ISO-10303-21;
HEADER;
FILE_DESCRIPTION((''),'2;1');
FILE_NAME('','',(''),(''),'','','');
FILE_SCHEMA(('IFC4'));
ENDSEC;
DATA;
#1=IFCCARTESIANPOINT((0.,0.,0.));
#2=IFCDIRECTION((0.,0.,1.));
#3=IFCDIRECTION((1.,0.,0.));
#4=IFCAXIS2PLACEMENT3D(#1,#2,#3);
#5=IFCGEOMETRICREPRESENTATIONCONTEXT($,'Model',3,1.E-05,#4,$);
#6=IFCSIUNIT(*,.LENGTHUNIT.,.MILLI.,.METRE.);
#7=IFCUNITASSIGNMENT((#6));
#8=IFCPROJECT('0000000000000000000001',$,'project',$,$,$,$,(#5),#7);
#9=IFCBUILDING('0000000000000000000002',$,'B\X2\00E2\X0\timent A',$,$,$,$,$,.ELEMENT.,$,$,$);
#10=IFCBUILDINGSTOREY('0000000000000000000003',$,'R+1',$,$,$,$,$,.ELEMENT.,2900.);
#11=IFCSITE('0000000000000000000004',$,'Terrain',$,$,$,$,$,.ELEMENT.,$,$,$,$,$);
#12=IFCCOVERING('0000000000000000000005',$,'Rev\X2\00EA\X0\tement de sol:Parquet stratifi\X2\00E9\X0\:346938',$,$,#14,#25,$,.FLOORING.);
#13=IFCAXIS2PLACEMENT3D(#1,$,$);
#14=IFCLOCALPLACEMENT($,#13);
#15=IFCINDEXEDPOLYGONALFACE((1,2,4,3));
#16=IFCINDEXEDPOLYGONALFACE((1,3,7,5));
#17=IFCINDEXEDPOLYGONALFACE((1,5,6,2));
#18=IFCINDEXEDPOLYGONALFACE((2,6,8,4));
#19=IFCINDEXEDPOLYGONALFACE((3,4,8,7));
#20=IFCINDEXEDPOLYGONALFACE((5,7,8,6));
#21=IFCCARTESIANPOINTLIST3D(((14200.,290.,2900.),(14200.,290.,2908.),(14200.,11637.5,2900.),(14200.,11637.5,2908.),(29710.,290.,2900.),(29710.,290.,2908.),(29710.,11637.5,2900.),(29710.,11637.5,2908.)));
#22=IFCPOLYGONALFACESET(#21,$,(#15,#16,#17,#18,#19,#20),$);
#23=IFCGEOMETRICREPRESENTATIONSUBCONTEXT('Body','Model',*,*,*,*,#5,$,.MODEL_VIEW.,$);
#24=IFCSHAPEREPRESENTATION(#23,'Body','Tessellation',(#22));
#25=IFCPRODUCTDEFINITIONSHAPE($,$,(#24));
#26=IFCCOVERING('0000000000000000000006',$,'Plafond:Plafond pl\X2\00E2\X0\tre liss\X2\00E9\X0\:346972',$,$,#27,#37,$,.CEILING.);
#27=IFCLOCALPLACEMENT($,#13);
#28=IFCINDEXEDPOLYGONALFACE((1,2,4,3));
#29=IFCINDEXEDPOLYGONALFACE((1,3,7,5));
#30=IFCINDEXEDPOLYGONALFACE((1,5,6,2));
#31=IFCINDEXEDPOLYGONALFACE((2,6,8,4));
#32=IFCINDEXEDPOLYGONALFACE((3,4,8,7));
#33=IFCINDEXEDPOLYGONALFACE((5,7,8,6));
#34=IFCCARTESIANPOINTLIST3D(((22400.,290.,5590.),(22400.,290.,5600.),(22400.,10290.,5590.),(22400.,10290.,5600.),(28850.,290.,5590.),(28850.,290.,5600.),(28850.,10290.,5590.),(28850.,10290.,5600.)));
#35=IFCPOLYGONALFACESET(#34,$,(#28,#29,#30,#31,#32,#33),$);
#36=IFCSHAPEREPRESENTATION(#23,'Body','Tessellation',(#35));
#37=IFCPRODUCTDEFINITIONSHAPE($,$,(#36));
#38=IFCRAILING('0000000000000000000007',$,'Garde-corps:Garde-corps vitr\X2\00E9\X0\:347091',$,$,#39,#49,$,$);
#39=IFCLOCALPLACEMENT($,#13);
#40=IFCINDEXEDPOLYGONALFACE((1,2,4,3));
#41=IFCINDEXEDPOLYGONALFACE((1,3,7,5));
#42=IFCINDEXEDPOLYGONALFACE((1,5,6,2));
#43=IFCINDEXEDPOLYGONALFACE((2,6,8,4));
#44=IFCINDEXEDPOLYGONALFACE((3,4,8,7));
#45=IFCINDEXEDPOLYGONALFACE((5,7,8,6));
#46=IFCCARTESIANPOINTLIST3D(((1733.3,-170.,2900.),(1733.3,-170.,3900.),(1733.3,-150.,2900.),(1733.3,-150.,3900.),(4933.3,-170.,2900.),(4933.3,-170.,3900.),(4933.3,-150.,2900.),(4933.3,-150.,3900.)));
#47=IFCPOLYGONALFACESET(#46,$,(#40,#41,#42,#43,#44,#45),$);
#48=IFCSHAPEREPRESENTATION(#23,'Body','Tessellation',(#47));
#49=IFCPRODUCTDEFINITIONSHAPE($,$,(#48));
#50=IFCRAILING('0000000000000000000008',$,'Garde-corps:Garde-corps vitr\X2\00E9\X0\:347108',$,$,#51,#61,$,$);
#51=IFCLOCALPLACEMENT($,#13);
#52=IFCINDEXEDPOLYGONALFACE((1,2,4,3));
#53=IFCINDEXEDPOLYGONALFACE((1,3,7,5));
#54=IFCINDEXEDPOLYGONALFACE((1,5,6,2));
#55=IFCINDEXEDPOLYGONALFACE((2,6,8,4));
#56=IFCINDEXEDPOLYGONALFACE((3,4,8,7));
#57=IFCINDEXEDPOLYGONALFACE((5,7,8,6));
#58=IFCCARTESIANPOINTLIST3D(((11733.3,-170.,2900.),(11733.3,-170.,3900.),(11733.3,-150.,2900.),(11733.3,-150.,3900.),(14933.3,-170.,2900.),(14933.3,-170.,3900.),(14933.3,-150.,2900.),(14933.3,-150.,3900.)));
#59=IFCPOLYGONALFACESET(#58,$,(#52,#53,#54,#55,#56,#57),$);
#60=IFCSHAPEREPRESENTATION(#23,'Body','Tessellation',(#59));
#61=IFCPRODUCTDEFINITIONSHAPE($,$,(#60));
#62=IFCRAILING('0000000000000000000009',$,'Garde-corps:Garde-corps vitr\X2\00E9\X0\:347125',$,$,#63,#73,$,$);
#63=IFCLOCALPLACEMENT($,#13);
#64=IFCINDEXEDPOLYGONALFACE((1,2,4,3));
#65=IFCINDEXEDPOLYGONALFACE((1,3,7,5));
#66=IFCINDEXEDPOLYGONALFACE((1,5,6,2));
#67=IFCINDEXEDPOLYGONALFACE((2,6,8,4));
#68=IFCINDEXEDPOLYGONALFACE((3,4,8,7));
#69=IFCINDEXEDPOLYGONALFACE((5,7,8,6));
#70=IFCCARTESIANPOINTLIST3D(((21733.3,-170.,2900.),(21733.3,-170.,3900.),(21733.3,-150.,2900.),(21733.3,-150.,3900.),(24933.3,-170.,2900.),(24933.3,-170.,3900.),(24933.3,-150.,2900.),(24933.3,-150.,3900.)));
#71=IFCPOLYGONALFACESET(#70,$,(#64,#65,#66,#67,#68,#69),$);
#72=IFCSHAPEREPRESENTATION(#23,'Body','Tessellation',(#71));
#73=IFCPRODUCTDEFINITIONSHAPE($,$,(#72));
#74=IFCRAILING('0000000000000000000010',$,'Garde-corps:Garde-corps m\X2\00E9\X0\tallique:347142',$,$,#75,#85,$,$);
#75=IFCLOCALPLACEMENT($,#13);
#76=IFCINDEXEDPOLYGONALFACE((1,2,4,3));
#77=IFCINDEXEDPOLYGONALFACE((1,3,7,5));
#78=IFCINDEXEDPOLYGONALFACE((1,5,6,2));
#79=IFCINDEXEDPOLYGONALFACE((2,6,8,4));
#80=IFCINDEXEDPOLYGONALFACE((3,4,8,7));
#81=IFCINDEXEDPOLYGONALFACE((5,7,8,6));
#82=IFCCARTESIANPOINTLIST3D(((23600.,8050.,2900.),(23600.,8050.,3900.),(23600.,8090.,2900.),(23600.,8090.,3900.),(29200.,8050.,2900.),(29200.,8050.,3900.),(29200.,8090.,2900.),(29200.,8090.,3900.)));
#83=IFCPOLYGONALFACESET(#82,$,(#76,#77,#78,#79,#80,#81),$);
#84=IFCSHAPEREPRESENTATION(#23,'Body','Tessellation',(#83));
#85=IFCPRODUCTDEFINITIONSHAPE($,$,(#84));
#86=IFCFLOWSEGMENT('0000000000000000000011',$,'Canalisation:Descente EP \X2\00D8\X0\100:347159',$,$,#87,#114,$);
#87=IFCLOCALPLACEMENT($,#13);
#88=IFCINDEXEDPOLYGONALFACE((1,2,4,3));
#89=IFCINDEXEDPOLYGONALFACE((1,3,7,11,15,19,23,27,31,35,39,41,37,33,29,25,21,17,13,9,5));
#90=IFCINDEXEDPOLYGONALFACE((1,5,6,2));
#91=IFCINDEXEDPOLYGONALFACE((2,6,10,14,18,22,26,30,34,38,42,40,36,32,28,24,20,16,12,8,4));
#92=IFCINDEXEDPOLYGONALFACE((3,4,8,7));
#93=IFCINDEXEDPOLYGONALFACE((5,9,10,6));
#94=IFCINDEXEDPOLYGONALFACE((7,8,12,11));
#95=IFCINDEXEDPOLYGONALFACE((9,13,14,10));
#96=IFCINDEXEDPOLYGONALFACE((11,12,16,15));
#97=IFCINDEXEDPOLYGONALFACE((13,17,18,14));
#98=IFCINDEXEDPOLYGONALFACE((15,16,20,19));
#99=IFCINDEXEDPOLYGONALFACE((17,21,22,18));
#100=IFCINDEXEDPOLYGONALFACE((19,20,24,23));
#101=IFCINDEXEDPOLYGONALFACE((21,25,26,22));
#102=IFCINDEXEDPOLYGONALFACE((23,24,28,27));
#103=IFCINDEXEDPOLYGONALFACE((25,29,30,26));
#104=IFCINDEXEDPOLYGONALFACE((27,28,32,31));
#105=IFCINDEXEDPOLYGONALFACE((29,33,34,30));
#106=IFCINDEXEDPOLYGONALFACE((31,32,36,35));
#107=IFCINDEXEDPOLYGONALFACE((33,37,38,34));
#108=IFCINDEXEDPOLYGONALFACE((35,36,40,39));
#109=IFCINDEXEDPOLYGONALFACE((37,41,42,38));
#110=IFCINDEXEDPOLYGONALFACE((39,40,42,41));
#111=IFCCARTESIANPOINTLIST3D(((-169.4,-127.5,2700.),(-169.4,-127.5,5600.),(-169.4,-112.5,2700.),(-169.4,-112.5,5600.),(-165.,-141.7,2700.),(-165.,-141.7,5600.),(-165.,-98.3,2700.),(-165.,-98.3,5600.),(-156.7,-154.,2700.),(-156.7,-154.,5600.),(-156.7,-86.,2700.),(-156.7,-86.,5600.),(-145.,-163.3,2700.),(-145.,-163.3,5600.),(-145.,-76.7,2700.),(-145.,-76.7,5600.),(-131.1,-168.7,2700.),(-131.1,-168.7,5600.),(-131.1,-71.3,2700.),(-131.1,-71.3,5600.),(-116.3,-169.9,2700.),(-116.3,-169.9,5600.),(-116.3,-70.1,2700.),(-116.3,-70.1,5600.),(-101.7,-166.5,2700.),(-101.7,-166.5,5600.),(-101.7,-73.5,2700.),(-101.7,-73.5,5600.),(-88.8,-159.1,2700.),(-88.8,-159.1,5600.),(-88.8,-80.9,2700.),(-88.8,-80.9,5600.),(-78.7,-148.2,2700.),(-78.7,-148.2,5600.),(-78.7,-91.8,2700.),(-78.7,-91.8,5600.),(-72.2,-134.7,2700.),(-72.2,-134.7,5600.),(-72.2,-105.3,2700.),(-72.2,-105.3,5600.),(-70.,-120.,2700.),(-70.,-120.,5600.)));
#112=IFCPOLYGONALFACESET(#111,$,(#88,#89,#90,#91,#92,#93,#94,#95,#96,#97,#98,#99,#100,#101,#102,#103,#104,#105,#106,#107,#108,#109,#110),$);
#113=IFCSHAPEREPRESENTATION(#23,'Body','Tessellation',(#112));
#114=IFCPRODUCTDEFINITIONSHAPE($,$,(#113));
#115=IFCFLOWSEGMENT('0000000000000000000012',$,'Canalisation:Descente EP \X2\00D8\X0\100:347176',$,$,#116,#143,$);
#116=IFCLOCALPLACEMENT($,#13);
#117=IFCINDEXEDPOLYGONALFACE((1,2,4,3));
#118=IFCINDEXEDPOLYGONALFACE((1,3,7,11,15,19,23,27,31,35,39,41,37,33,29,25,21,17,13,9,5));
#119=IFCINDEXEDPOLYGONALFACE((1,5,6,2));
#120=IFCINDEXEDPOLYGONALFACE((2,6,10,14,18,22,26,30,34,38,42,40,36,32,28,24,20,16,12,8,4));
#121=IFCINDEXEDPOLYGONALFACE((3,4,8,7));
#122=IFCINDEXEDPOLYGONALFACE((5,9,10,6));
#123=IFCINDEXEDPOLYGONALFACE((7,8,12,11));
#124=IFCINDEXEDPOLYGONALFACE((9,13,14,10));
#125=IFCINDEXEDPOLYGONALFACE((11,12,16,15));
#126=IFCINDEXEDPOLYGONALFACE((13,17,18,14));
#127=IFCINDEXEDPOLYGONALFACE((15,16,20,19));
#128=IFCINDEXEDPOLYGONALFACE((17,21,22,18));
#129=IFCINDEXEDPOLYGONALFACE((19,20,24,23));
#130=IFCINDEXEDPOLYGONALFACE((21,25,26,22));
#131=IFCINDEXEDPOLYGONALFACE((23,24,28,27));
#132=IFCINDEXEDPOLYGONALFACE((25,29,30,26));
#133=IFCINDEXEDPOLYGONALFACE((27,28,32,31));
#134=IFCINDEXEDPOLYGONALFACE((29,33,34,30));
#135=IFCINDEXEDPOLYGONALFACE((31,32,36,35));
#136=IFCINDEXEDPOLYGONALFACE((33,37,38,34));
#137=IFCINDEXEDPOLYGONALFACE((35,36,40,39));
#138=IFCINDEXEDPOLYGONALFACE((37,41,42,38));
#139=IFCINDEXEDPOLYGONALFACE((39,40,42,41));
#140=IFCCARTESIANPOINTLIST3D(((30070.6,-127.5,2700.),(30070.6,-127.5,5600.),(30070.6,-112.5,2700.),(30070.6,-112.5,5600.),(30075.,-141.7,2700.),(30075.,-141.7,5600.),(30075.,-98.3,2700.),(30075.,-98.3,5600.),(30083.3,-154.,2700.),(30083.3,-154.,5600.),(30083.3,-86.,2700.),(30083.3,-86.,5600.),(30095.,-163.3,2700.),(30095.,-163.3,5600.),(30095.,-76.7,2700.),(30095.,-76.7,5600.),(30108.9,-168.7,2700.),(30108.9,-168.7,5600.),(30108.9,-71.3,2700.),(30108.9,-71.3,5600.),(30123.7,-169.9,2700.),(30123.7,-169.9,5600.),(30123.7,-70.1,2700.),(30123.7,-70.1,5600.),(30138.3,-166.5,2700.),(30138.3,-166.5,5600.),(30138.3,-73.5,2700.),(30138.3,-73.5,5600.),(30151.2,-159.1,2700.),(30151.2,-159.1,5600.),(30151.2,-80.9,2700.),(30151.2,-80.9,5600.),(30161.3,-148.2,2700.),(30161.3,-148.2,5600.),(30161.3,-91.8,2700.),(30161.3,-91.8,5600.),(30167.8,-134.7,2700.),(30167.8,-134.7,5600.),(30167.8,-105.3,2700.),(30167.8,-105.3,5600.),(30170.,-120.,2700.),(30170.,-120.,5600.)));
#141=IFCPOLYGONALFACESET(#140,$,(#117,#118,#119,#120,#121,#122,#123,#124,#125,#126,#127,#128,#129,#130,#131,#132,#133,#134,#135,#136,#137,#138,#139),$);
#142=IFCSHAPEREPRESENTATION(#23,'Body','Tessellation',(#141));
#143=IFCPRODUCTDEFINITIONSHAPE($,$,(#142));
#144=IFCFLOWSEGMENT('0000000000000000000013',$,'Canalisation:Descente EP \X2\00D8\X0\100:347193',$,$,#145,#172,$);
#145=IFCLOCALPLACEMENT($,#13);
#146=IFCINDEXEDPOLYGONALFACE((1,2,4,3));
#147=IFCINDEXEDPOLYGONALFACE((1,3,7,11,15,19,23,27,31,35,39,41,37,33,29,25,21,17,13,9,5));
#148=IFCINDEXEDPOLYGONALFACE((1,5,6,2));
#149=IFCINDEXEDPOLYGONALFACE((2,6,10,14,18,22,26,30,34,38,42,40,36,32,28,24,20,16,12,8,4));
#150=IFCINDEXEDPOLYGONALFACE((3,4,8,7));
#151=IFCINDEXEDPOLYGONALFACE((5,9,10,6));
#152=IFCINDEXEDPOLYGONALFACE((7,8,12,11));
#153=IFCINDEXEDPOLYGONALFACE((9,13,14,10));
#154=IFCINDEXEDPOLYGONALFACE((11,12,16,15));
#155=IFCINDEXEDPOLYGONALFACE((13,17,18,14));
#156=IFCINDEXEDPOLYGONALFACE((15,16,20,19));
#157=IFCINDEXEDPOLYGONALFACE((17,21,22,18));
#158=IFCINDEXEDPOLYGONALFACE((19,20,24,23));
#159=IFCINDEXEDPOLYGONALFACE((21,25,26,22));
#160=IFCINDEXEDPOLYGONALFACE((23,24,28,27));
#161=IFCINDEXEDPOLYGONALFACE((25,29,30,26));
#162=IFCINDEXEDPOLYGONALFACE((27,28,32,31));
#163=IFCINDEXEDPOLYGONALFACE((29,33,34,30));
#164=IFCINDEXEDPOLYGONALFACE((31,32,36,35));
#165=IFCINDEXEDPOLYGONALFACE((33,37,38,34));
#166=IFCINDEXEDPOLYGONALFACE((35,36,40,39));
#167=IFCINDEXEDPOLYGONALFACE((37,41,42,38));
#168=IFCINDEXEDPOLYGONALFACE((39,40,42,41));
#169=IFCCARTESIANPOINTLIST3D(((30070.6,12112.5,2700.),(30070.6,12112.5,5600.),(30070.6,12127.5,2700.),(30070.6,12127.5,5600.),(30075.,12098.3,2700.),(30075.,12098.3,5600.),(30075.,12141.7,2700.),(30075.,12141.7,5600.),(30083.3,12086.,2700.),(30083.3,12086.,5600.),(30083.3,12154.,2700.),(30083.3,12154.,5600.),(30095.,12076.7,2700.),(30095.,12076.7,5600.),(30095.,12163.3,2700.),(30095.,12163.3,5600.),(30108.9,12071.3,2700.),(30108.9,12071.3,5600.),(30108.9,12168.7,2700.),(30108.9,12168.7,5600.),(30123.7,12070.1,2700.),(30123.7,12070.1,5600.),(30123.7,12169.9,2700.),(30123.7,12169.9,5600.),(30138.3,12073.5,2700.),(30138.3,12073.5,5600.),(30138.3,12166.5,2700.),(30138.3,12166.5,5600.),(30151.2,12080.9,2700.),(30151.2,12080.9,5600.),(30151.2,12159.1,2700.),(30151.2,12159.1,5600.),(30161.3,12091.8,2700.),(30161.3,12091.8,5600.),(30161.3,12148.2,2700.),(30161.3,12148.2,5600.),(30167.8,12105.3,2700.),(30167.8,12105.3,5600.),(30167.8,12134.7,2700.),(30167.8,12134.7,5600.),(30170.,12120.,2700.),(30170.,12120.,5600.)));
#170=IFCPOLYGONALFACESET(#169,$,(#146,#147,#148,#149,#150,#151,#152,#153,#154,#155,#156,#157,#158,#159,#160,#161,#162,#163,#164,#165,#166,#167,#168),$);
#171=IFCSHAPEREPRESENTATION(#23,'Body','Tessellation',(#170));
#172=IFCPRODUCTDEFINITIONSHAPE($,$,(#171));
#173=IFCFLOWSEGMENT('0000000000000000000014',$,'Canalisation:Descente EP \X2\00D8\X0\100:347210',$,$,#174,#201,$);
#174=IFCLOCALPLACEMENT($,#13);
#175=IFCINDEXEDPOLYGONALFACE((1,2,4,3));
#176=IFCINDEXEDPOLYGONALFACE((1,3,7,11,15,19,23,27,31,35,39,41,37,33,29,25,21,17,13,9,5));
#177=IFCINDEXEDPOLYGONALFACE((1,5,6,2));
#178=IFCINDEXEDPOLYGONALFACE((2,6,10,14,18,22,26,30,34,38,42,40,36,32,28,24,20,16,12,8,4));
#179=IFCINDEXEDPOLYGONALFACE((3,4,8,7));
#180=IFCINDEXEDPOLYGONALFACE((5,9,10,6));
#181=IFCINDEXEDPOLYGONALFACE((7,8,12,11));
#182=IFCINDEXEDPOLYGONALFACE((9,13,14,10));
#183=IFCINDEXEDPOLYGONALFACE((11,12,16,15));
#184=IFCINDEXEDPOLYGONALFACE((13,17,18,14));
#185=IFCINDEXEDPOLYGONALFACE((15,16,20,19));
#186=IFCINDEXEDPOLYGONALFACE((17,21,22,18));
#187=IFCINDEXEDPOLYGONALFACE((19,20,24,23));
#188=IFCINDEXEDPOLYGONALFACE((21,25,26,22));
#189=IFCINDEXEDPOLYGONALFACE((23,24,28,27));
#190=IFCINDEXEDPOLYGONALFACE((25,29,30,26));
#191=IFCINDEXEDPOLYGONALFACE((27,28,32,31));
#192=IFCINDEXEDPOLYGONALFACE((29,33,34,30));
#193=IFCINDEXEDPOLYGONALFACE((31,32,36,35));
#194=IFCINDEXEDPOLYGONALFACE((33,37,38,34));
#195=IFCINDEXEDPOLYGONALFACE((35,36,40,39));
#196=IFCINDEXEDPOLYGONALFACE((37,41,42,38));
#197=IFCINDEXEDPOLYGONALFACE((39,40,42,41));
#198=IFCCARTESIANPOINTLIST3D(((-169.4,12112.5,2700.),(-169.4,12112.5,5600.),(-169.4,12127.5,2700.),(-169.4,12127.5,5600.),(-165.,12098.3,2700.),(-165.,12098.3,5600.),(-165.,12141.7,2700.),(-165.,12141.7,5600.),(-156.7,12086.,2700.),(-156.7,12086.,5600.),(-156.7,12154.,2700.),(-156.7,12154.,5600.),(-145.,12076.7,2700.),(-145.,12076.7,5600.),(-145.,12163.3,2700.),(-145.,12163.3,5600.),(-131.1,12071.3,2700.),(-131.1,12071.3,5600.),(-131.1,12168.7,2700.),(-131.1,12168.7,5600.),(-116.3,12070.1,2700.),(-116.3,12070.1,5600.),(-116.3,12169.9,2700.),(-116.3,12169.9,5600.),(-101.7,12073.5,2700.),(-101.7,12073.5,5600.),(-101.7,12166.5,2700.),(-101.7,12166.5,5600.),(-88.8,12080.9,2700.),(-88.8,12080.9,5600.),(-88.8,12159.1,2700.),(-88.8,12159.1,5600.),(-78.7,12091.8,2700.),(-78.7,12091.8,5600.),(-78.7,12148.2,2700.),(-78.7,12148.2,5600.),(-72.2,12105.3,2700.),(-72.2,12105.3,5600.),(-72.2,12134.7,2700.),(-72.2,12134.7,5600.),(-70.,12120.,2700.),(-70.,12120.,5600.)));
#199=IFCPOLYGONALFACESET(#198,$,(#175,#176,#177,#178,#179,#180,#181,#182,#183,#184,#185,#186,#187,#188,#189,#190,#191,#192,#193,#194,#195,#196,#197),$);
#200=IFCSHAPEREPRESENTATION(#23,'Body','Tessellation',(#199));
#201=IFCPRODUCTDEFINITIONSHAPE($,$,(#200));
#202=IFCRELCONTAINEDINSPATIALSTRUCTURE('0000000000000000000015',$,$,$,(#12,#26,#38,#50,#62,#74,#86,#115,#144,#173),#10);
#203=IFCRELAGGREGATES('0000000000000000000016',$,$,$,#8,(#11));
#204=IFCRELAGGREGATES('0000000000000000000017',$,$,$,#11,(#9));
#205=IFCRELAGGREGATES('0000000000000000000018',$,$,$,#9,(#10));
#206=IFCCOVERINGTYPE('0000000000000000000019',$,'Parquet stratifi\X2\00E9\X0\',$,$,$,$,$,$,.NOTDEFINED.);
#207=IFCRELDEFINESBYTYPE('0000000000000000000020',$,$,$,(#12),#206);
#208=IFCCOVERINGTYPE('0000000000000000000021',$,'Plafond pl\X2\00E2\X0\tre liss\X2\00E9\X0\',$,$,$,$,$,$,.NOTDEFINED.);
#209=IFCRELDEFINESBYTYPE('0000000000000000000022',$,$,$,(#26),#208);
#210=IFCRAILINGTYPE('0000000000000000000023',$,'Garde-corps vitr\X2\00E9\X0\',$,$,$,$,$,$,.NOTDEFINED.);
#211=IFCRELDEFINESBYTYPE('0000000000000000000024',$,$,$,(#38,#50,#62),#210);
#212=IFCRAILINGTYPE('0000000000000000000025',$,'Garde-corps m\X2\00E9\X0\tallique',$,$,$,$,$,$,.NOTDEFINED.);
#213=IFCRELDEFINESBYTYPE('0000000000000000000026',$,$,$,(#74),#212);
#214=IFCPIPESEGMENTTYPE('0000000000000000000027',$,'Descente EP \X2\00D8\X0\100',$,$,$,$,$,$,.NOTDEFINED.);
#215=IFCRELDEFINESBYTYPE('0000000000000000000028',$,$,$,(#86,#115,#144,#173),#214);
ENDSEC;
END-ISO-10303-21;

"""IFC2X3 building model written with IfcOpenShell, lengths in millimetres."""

from ifc_helpers import new_model, si_unit, frame, frame_2d, origin_with_axes, origin_2d, place, context, subcontext, project, spatial, rectangle, circle, extrude, type_object, element, save


model = new_model("IFC2X3")

# Units and contexts
model_context = context("Model", 3, precision=1e-05, world=origin_with_axes())
body_context = subcontext(model_context, "Body", "Model", "MODEL_VIEW")
ifc_project = project(units=[si_unit("LENGTHUNIT", "METRE", prefix="MILLI")], contexts=[model_context])

# Site, building, storey
site = spatial("IfcSite", under=ifc_project, Name="Terrain", CompositionType="ELEMENT")
building = spatial("IfcBuilding", under=site, Name="Bâtiment A", CompositionType="ELEMENT")
storey = spatial("IfcBuildingStorey", under=building, Name="R+1", CompositionType="ELEMENT", Elevation=2900.0)

# Coverings
covering_type_1 = type_object("IfcCoveringType", Name="Parquet stratifié", PredefinedType="NOTDEFINED")
covering_1_placement = place(None, origin_with_axes())
element("IfcCovering", 1, at=covering_1_placement, inside=storey, type_object=covering_type_1, Name="Revêtement de sol:Parquet stratifié:346938", PredefinedType="FLOORING", context=body_context, shape_type="SweptSolid", body=[
    extrude(rectangle(XDim=15510.0, YDim=11347.5, at=frame_2d((21955.0, 5963.8))), frame((0.0, 0.0, 2900.0), z_axis=(0.0, 0.0, 1.0), x_axis=(1.0, 0.0, 0.0)), (0.0, 0.0, 1.0), 8.0),
])
covering_type_2 = type_object("IfcCoveringType", Name="Plafond plâtre lissé", PredefinedType="NOTDEFINED")
covering_2_placement = place(None, origin_with_axes())
element("IfcCovering", 2, at=covering_2_placement, inside=storey, type_object=covering_type_2, Name="Plafond:Plafond plâtre lissé:346972", PredefinedType="CEILING", context=body_context, shape_type="SweptSolid", body=[
    extrude(rectangle(XDim=6450.0, YDim=10000.0, at=frame_2d((25625.0, 5290.0))), frame((0.0, 0.0, 5590.0), z_axis=(0.0, 0.0, 1.0), x_axis=(1.0, 0.0, 0.0)), (0.0, 0.0, 1.0), 10.0),
])

# Railings
railing_type_1 = type_object("IfcRailingType", Name="Garde-corps vitré", PredefinedType="NOTDEFINED")
railing_1_placement = place(None, origin_with_axes())
element("IfcRailing", 3, at=railing_1_placement, inside=storey, type_object=railing_type_1, Name="Garde-corps:Garde-corps vitré:347091", context=body_context, shape_type="SweptSolid", body=[
    extrude(rectangle(XDim=3200.0, YDim=20.0, at=frame_2d((3333.3, -160.0))), frame((0.0, 0.0, 2900.0), z_axis=(0.0, 0.0, 1.0), x_axis=(1.0, 0.0, 0.0)), (0.0, 0.0, 1.0), 1000.0),
])
railing_2_placement = place(None, origin_with_axes())
element("IfcRailing", 4, at=railing_2_placement, inside=storey, type_object=railing_type_1, Name="Garde-corps:Garde-corps vitré:347108", context=body_context, shape_type="SweptSolid", body=[
    extrude(rectangle(XDim=3200.0, YDim=20.0, at=frame_2d((13333.3, -160.0))), frame((0.0, 0.0, 2900.0), z_axis=(0.0, 0.0, 1.0), x_axis=(1.0, 0.0, 0.0)), (0.0, 0.0, 1.0), 1000.0),
])
railing_3_placement = place(None, origin_with_axes())
element("IfcRailing", 5, at=railing_3_placement, inside=storey, type_object=railing_type_1, Name="Garde-corps:Garde-corps vitré:347125", context=body_context, shape_type="SweptSolid", body=[
    extrude(rectangle(XDim=3200.0, YDim=20.0, at=frame_2d((23333.3, -160.0))), frame((0.0, 0.0, 2900.0), z_axis=(0.0, 0.0, 1.0), x_axis=(1.0, 0.0, 0.0)), (0.0, 0.0, 1.0), 1000.0),
])
railing_type_2 = type_object("IfcRailingType", Name="Garde-corps métallique", PredefinedType="NOTDEFINED")
railing_4_placement = place(None, origin_with_axes())
element("IfcRailing", 6, at=railing_4_placement, inside=storey, type_object=railing_type_2, Name="Garde-corps:Garde-corps métallique:347142", context=body_context, shape_type="SweptSolid", body=[
    extrude(rectangle(XDim=5600.0, YDim=40.0, at=frame_2d((26400.0, 8070.0))), frame((0.0, 0.0, 2900.0), z_axis=(0.0, 0.0, 1.0), x_axis=(1.0, 0.0, 0.0)), (0.0, 0.0, 1.0), 1000.0),
])

# Flow segments
pipe_segment_type = type_object("IfcPipeSegmentType", Name="Descente EP Ø100", PredefinedType="NOTDEFINED")
flow_segment_1_placement = place(None, origin_with_axes())
element("IfcFlowSegment", 7, at=flow_segment_1_placement, inside=storey, type_object=pipe_segment_type, Name="Canalisation:Descente EP Ø100:347159", context=body_context, shape_type="SweptSolid", body=[
    extrude(circle(Radius=50.0, at=origin_2d()), frame((-120.0, -120.0, 2700.0), z_axis=(0.0, 0.0, 1.0), x_axis=(1.0, 0.0, 0.0)), (0.0, 0.0, 1.0), 2900.0),
])
flow_segment_2_placement = place(None, origin_with_axes())
element("IfcFlowSegment", 8, at=flow_segment_2_placement, inside=storey, type_object=pipe_segment_type, Name="Canalisation:Descente EP Ø100:347176", context=body_context, shape_type="SweptSolid", body=[
    extrude(circle(Radius=50.0, at=origin_2d()), frame((30120.0, -120.0, 2700.0), z_axis=(0.0, 0.0, 1.0), x_axis=(1.0, 0.0, 0.0)), (0.0, 0.0, 1.0), 2900.0),
])
flow_segment_3_placement = place(None, origin_with_axes())
element("IfcFlowSegment", 9, at=flow_segment_3_placement, inside=storey, type_object=pipe_segment_type, Name="Canalisation:Descente EP Ø100:347193", context=body_context, shape_type="SweptSolid", body=[
    extrude(circle(Radius=50.0, at=origin_2d()), frame((30120.0, 12120.0, 2700.0), z_axis=(0.0, 0.0, 1.0), x_axis=(1.0, 0.0, 0.0)), (0.0, 0.0, 1.0), 2900.0),
])
flow_segment_4_placement = place(None, origin_with_axes())
element("IfcFlowSegment", 10, at=flow_segment_4_placement, inside=storey, type_object=pipe_segment_type, Name="Canalisation:Descente EP Ø100:347210", context=body_context, shape_type="SweptSolid", body=[
    extrude(circle(Radius=50.0, at=origin_2d()), frame((-120.0, 12120.0, 2700.0), z_axis=(0.0, 0.0, 1.0), x_axis=(1.0, 0.0, 0.0)), (0.0, 0.0, 1.0), 2900.0),
])

save(model, "model.ifc")
